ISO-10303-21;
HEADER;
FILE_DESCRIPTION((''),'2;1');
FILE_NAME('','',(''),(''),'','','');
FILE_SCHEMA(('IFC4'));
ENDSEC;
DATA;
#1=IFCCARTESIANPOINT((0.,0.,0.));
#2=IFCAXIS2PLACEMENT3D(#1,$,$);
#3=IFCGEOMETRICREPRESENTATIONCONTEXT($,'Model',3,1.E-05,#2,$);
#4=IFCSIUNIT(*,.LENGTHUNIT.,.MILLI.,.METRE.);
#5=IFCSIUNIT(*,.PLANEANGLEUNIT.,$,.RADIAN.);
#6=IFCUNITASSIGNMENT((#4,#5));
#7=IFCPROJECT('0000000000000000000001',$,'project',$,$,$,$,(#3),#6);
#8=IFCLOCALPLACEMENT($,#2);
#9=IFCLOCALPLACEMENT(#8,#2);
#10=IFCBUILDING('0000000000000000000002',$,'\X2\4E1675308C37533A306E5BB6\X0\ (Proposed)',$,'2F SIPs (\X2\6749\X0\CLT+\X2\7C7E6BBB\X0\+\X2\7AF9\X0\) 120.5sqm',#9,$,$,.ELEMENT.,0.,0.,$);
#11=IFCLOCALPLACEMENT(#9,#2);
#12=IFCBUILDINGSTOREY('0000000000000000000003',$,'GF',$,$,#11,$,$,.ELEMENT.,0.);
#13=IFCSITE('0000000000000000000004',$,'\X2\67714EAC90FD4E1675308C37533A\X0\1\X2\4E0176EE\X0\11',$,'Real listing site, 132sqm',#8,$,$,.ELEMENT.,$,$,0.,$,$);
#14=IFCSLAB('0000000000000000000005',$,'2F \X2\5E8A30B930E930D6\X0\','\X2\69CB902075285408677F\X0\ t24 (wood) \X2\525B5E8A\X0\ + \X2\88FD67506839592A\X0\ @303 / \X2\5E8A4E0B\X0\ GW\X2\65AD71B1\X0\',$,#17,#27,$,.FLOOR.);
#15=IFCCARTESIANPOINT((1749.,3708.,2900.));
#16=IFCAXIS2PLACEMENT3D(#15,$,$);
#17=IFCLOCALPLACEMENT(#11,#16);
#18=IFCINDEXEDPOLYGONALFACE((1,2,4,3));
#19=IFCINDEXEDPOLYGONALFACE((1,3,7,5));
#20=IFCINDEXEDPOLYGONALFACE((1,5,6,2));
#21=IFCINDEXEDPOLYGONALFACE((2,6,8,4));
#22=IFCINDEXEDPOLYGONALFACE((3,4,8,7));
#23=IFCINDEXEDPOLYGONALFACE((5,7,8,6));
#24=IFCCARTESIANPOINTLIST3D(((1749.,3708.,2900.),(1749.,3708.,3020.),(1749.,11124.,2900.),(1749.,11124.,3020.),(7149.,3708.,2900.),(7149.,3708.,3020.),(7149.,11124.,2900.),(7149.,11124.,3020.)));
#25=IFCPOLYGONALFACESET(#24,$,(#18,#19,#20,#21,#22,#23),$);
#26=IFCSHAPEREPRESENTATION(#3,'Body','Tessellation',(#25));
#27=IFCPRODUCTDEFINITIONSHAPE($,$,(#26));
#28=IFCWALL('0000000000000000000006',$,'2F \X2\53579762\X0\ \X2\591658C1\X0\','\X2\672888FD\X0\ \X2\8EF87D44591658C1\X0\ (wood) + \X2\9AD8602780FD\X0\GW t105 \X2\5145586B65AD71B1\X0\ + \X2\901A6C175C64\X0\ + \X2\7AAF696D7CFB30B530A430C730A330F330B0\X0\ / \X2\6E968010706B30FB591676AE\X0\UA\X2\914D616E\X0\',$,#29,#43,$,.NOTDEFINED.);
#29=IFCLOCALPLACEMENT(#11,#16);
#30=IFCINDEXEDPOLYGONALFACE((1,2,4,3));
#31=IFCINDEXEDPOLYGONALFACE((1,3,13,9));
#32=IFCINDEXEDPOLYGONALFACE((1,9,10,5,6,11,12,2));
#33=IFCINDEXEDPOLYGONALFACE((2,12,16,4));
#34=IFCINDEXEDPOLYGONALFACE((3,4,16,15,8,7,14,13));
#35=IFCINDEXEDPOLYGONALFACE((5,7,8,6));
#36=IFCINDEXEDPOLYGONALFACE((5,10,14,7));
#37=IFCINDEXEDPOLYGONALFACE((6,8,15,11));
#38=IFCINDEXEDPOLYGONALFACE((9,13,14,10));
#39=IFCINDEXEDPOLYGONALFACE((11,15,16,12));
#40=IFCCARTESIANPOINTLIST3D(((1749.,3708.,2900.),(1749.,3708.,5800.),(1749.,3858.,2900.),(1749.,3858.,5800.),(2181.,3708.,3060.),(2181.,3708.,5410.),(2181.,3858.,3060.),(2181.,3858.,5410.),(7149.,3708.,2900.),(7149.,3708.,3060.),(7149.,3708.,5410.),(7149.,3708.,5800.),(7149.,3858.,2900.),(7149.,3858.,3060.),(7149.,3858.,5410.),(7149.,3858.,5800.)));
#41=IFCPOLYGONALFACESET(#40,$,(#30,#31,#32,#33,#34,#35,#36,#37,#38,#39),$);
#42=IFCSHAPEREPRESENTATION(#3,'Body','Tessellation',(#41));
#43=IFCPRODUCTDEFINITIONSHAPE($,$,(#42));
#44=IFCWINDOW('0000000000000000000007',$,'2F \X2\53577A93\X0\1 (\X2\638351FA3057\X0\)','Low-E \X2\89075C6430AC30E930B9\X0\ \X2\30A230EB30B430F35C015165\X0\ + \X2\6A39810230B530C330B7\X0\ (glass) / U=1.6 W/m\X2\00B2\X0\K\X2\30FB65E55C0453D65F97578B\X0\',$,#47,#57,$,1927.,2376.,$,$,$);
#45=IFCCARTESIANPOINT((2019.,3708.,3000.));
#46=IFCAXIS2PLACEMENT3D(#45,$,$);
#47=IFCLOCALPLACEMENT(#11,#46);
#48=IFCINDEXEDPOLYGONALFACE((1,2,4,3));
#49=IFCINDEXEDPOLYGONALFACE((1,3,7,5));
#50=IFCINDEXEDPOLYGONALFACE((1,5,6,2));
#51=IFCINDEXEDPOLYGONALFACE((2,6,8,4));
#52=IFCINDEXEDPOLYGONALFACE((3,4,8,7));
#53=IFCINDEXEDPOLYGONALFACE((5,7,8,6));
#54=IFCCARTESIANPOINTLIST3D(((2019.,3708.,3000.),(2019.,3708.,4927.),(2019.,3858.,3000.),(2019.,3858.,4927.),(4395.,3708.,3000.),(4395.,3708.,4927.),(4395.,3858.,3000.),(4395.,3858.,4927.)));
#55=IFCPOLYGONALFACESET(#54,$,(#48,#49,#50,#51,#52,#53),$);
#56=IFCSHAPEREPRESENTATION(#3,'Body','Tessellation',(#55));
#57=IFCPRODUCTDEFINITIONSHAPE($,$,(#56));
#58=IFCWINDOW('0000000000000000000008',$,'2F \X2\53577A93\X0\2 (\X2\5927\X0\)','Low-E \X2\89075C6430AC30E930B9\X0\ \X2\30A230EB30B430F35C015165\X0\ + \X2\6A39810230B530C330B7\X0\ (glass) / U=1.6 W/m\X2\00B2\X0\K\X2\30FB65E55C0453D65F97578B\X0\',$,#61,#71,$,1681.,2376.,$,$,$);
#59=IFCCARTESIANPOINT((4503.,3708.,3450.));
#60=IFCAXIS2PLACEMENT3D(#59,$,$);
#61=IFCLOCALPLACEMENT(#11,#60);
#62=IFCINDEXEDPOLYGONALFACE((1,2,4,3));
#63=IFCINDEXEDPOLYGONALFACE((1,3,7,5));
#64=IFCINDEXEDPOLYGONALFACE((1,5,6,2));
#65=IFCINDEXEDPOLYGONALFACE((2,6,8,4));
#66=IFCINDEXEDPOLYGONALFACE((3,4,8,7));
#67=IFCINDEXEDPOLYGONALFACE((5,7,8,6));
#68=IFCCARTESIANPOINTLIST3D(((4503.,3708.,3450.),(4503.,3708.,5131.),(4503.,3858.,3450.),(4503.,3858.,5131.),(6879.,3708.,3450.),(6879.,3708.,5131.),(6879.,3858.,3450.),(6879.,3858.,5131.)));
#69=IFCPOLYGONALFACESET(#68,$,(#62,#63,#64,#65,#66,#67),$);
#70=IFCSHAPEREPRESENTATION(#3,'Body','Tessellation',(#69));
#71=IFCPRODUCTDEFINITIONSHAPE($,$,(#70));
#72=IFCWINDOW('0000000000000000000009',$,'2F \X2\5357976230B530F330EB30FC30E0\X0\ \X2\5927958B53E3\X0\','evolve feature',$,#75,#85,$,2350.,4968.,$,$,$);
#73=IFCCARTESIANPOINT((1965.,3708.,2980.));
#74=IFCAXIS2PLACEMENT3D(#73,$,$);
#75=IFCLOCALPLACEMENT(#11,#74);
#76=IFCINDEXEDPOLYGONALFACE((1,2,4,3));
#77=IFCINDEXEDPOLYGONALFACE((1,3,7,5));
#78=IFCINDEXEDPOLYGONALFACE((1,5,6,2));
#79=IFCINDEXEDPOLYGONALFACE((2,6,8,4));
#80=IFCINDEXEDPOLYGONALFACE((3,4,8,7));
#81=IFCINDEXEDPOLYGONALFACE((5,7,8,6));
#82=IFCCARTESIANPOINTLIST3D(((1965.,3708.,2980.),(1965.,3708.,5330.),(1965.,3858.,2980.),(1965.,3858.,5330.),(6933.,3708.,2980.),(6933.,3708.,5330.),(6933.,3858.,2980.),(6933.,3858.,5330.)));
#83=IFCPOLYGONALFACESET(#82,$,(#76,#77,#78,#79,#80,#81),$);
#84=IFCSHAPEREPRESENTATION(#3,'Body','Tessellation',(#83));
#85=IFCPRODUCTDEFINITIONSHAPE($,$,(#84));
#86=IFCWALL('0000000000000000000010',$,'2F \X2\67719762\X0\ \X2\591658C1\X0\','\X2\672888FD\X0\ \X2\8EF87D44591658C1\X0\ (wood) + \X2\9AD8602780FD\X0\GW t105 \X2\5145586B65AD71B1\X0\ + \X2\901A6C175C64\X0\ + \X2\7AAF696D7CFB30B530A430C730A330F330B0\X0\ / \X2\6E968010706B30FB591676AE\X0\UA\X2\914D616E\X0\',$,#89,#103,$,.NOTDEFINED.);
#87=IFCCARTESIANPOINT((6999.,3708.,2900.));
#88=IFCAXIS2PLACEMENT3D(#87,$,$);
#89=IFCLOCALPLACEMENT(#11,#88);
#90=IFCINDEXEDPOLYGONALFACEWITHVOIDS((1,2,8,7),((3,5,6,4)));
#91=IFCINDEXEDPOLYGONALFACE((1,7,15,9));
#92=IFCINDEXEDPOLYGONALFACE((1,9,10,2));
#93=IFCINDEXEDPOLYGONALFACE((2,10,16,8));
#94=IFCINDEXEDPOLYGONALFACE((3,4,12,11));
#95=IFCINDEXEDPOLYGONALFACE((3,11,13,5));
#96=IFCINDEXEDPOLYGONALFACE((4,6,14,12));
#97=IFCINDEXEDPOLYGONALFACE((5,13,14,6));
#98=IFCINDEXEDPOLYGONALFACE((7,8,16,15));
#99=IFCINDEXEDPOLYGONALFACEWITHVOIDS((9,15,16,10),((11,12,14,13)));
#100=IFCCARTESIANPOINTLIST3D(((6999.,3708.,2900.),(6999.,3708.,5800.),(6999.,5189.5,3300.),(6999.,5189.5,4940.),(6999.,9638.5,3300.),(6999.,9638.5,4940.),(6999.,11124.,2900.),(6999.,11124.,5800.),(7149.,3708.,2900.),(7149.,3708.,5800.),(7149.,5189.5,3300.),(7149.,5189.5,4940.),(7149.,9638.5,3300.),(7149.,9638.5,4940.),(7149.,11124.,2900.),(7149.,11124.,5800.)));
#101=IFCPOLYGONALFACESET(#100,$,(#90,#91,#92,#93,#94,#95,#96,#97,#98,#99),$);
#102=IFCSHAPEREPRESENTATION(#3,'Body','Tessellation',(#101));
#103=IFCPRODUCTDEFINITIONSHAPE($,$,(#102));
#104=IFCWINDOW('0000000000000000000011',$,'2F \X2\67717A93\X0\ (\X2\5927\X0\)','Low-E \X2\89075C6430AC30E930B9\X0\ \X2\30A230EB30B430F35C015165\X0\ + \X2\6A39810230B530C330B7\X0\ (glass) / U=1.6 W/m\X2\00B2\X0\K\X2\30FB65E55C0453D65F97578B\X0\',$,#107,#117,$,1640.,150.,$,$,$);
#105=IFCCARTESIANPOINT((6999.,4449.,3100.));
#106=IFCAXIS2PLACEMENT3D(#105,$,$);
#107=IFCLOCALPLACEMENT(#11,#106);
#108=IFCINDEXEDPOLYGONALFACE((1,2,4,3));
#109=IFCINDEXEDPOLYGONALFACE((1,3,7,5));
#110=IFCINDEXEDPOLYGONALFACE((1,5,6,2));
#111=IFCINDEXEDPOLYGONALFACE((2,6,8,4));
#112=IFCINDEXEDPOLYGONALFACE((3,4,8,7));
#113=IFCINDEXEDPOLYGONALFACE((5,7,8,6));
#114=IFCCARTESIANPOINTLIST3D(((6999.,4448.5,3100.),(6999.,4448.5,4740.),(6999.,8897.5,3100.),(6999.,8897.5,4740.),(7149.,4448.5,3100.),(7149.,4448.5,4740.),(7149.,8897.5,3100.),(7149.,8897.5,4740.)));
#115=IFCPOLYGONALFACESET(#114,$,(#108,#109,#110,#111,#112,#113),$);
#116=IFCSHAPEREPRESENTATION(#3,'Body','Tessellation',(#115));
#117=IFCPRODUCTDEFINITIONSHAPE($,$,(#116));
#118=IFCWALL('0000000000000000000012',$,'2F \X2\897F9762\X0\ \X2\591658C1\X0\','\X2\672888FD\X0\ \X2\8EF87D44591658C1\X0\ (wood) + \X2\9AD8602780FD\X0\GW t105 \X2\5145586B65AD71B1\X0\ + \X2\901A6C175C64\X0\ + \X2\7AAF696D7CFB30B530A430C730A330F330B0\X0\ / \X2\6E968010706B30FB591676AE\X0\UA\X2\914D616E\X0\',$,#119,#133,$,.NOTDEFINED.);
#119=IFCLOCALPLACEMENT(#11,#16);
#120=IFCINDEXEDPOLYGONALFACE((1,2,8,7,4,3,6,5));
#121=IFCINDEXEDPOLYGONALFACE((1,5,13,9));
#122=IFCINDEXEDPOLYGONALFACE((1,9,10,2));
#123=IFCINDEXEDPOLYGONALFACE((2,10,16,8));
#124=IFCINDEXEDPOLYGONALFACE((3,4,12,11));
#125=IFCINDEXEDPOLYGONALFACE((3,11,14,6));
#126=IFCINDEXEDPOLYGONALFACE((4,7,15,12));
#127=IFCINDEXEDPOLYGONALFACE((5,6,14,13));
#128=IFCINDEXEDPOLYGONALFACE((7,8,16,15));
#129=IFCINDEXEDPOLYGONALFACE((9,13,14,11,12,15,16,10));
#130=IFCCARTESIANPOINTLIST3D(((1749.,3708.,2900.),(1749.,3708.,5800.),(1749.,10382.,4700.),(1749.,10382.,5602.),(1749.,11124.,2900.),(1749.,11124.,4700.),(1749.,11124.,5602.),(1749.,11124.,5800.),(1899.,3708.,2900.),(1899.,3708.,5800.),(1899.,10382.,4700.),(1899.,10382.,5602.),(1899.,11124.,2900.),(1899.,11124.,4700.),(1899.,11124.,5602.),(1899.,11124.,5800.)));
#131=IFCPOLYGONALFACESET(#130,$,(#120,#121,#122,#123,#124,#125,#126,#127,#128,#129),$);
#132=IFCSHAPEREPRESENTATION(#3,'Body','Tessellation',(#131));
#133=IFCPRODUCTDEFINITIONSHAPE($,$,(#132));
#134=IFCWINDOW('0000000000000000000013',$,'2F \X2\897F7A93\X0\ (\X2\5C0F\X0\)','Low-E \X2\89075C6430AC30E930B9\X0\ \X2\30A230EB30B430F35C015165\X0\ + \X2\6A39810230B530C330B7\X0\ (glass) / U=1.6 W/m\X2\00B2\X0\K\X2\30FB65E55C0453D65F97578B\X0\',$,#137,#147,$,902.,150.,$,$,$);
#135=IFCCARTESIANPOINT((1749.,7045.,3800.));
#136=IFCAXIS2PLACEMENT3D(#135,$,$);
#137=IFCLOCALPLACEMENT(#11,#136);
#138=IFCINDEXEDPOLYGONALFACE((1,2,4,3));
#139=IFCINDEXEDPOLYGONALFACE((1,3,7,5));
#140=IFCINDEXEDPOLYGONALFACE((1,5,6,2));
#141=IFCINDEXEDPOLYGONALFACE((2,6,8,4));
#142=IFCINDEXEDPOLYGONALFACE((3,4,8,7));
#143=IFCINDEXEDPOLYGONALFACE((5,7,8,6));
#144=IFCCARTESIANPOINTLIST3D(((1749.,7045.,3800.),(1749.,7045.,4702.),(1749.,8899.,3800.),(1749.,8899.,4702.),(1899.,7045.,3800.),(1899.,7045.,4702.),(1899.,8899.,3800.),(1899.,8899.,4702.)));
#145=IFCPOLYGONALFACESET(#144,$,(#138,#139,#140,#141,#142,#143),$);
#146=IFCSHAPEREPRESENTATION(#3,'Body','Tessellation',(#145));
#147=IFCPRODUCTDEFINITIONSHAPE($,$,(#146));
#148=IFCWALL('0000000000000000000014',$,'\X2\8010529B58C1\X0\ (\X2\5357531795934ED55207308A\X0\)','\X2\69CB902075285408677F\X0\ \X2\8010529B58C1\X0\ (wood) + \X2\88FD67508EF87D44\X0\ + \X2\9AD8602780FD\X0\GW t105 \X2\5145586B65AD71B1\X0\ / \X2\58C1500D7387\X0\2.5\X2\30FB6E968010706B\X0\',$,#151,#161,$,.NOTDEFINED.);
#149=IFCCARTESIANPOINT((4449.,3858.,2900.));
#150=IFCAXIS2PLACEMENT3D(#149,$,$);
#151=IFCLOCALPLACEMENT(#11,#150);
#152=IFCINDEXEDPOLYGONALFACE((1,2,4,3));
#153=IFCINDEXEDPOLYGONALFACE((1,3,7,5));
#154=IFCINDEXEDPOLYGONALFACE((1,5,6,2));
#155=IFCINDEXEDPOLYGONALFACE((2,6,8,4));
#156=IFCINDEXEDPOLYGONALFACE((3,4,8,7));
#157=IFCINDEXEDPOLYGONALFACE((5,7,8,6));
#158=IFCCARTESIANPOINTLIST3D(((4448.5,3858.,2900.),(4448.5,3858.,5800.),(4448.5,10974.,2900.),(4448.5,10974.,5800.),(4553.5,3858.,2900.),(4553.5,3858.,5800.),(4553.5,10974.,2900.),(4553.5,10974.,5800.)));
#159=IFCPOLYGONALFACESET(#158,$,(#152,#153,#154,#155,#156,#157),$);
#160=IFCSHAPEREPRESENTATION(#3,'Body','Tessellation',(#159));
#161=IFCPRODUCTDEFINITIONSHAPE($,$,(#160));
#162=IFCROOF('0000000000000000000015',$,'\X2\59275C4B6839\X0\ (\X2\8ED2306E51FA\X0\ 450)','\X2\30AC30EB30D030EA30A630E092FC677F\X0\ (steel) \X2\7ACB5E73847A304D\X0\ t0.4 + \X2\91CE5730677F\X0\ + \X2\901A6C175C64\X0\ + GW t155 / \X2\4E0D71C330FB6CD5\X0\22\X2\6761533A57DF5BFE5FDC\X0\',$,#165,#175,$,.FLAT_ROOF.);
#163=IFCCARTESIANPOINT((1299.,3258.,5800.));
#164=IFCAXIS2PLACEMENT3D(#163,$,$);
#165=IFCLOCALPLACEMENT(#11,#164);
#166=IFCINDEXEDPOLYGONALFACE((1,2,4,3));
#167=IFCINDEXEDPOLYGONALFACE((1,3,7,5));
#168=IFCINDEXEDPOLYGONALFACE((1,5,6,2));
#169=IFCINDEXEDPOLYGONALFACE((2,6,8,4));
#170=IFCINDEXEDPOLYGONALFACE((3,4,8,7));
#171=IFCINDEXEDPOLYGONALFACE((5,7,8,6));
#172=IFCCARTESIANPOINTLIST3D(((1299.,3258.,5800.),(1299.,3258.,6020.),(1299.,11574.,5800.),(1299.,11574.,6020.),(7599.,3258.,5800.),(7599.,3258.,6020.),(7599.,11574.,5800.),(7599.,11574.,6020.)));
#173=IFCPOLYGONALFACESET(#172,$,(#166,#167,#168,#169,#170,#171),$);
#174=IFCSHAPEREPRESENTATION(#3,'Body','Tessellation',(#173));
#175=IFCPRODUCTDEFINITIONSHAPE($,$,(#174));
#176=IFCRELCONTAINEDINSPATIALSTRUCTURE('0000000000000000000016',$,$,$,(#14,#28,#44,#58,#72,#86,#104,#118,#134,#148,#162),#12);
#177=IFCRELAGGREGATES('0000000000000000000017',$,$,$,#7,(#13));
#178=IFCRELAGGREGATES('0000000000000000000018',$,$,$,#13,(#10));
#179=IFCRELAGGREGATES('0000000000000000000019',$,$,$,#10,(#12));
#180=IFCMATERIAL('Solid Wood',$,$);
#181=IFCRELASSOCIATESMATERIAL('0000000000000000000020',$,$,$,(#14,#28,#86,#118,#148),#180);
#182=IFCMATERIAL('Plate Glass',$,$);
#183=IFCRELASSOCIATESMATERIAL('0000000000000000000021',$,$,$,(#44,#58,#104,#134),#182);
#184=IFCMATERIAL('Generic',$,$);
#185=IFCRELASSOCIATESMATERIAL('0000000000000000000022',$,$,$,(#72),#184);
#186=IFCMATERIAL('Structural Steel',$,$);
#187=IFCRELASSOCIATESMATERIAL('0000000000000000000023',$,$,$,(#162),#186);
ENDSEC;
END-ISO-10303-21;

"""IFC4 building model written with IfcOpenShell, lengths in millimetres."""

from ifc_helpers import new_model, si_unit, frame, frame_2d, origin, place, context, project, spatial, rectangle, extrude, material, element, fill, save


model = new_model("IFC4")

# Units and contexts
model_context = context("Model", 3, precision=1e-05, world=origin())
ifc_project = project(units=[si_unit("LENGTHUNIT", "METRE", prefix="MILLI"), si_unit("PLANEANGLEUNIT", "RADIAN")], contexts=[model_context])

# Site, building, storey
site_placement = place(None, origin())
site = spatial("IfcSite", under=ifc_project, at=site_placement, Name="東京都世田谷区1丁目11", ObjectType="Real listing site, 132sqm", CompositionType="ELEMENT", RefElevation=0.0)
building_placement = place(site_placement, origin())
building = spatial("IfcBuilding", under=site, at=building_placement, Name="世田谷区の家 (Proposed)", ObjectType="2F SIPs (杉CLT+籾殻+竹) 120.5sqm", CompositionType="ELEMENT", ElevationOfRefHeight=0.0, ElevationOfTerrain=0.0)
storey_placement = place(building_placement, origin())
storey = spatial("IfcBuildingStorey", under=building, at=storey_placement, Name="GF", CompositionType="ELEMENT", Elevation=0.0)

# Slab
ifc_material_1 = material(Name="Solid Wood")
slab_placement = place(storey_placement, frame((1749.0, 3708.0, 2900.0)))
element("IfcSlab", 1, at=slab_placement, inside=storey, material=ifc_material_1, Name="2F 床スラブ", Description="構造用合板 t24 (wood) 剛床 + 製材根太 @303 / 床下 GW断熱", PredefinedType="FLOOR", context=model_context, shape_type="SweptSolid", body=[
    extrude(rectangle(XDim=5400.0, YDim=7416.0, at=frame_2d((2700.0, 3708.0))), frame((1749.0, 3708.0, 2900.0)), (0.0, 0.0, 1.0), 120.0),
])

# Wall, openings, windows
wall_1_placement = place(storey_placement, frame((1749.0, 3708.0, 2900.0)))
wall_1 = element("IfcWall", 2, at=wall_1_placement, inside=storey, material=ifc_material_1, Name="2F 南面 外壁", Description="木製 軸組外壁 (wood) + 高性能GW t105 充填断熱 + 通気層 + 窯業系サイディング / 準耐火・外皮UA配慮", PredefinedType="NOTDEFINED", context=model_context, shape_type="SweptSolid", body=[
    extrude(rectangle(XDim=5400.0, YDim=150.0, at=frame_2d((2700.0, 75.0))), frame((1749.0, 3708.0, 2900.0)), (0.0, 0.0, 1.0), 2900.0),
])
opening_1_placement = place(storey_placement, frame((2019.0, 3708.0, 3000.0)))
opening_1 = element("IfcOpeningElement", 3, at=opening_1_placement, cuts=wall_1, PredefinedType="NOTDEFINED", context=model_context, shape_type="SweptSolid", body=[
    extrude(rectangle(XDim=2376.0, YDim=150.0, at=frame_2d((1188.0, 75.0))), frame((2019.0, 3708.0, 3000.0)), (0.0, 0.0, 1.0), 1927.0),
])
opening_2_placement = place(storey_placement, frame((4503.0, 3708.0, 3450.0)))
opening_2 = element("IfcOpeningElement", 4, at=opening_2_placement, cuts=wall_1, PredefinedType="NOTDEFINED", context=model_context, shape_type="SweptSolid", body=[
    extrude(rectangle(XDim=2376.0, YDim=150.0, at=frame_2d((1188.0, 75.0))), frame((4503.0, 3708.0, 3450.0)), (0.0, 0.0, 1.0), 1681.0),
])
opening_3_placement = place(storey_placement, frame((1965.0, 3708.0, 2980.0)))
opening_3 = element("IfcOpeningElement", 5, at=opening_3_placement, cuts=wall_1, PredefinedType="NOTDEFINED", context=model_context, shape_type="SweptSolid", body=[
    extrude(rectangle(XDim=4968.0, YDim=150.0, at=frame_2d((2484.0, 75.0))), frame((1965.0, 3708.0, 2980.0)), (0.0, 0.0, 1.0), 2350.0),
])
ifc_material_2 = material(Name="Plate Glass")
window_1_placement = place(storey_placement, frame((2019.0, 3708.0, 3000.0)))
window_1 = element("IfcWindow", 6, at=window_1_placement, inside=storey, material=ifc_material_2, Name="2F 南窓1 (掃出し)", Description="Low-E 複層ガラス アルゴン封入 + 樹脂サッシ (glass) / U=1.6 W/m²K・日射取得型", OverallHeight=1927.0, OverallWidth=2376.0, context=model_context, shape_type="SweptSolid", body=[
    extrude(rectangle(XDim=2376.0, YDim=150.0, at=frame_2d((1188.0, 75.0))), frame((2019.0, 3708.0, 3000.0)), (0.0, 0.0, 1.0), 1927.0),
])
fill(opening_1, window_1)
window_2_placement = place(storey_placement, frame((4503.0, 3708.0, 3450.0)))
window_2 = element("IfcWindow", 7, at=window_2_placement, inside=storey, material=ifc_material_2, Name="2F 南窓2 (大)", Description="Low-E 複層ガラス アルゴン封入 + 樹脂サッシ (glass) / U=1.6 W/m²K・日射取得型", OverallHeight=1681.0, OverallWidth=2376.0, context=model_context, shape_type="SweptSolid", body=[
    extrude(rectangle(XDim=2376.0, YDim=150.0, at=frame_2d((1188.0, 75.0))), frame((4503.0, 3708.0, 3450.0)), (0.0, 0.0, 1.0), 1681.0),
])
fill(opening_2, window_2)
ifc_material_3 = material(Name="Generic")
window_3_placement = place(storey_placement, frame((1965.0, 3708.0, 2980.0)))
window_3 = element("IfcWindow", 8, at=window_3_placement, inside=storey, material=ifc_material_3, Name="2F 南面サンルーム 大開口", Description="evolve feature", OverallHeight=2350.0, OverallWidth=4968.0, context=model_context, shape_type="SweptSolid", body=[
    extrude(rectangle(XDim=4968.0, YDim=150.0, at=frame_2d((2484.0, 75.0))), frame((1965.0, 3708.0, 2980.0)), (0.0, 0.0, 1.0), 2350.0),
])
fill(opening_3, window_3)

# Walls, openings, windows
wall_2_placement = place(storey_placement, frame((6999.0, 3708.0, 2900.0)))
wall_2 = element("IfcWall", 9, at=wall_2_placement, inside=storey, material=ifc_material_1, Name="2F 東面 外壁", Description="木製 軸組外壁 (wood) + 高性能GW t105 充填断熱 + 通気層 + 窯業系サイディング / 準耐火・外皮UA配慮", PredefinedType="NOTDEFINED", context=model_context, shape_type="SweptSolid", body=[
    extrude(rectangle(XDim=150.0, YDim=7416.0, at=frame_2d((75.0, 3708.0))), frame((6999.0, 3708.0, 2900.0)), (0.0, 0.0, 1.0), 2900.0),
])
opening_4_placement = place(storey_placement, frame((6999.0, 4449.0, 3100.0)))
opening_4 = element("IfcOpeningElement", 10, at=opening_4_placement, cuts=wall_2, PredefinedType="NOTDEFINED", context=model_context, shape_type="SweptSolid", body=[
    extrude(rectangle(XDim=150.0, YDim=4449.0, at=frame_2d((75.0, 2224.0))), frame((6999.0, 4449.0, 3100.0)), (0.0, 0.0, 1.0), 1640.0),
])
window_4_placement = place(storey_placement, frame((6999.0, 4449.0, 3100.0)))
window_4 = element("IfcWindow", 11, at=window_4_placement, inside=storey, material=ifc_material_2, Name="2F 東窓 (大)", Description="Low-E 複層ガラス アルゴン封入 + 樹脂サッシ (glass) / U=1.6 W/m²K・日射取得型", OverallHeight=1640.0, OverallWidth=150.0, context=model_context, shape_type="SweptSolid", body=[
    extrude(rectangle(XDim=150.0, YDim=4449.0, at=frame_2d((75.0, 2224.0))), frame((6999.0, 4449.0, 3100.0)), (0.0, 0.0, 1.0), 1640.0),
])
fill(opening_4, window_4)
wall_3_placement = place(storey_placement, frame((1749.0, 3708.0, 2900.0)))
wall_3 = element("IfcWall", 12, at=wall_3_placement, inside=storey, material=ifc_material_1, Name="2F 西面 外壁", Description="木製 軸組外壁 (wood) + 高性能GW t105 充填断熱 + 通気層 + 窯業系サイディング / 準耐火・外皮UA配慮", PredefinedType="NOTDEFINED", context=model_context, shape_type="SweptSolid", body=[
    extrude(rectangle(XDim=150.0, YDim=7416.0, at=frame_2d((75.0, 3708.0))), frame((1749.0, 3708.0, 2900.0)), (0.0, 0.0, 1.0), 2900.0),
])
opening_5_placement = place(storey_placement, frame((1749.0, 7045.0, 3800.0)))
opening_5 = element("IfcOpeningElement", 13, at=opening_5_placement, cuts=wall_3, PredefinedType="NOTDEFINED", context=model_context, shape_type="SweptSolid", body=[
    extrude(rectangle(XDim=150.0, YDim=1854.0, at=frame_2d((75.0, 927.0))), frame((1749.0, 7045.0, 3800.0)), (0.0, 0.0, 1.0), 902.0),
])
window_5_placement = place(storey_placement, frame((1749.0, 7045.0, 3800.0)))
window_5 = element("IfcWindow", 14, at=window_5_placement, inside=storey, material=ifc_material_2, Name="2F 西窓 (小)", Description="Low-E 複層ガラス アルゴン封入 + 樹脂サッシ (glass) / U=1.6 W/m²K・日射取得型", OverallHeight=902.0, OverallWidth=150.0, context=model_context, shape_type="SweptSolid", body=[
    extrude(rectangle(XDim=150.0, YDim=1854.0, at=frame_2d((75.0, 927.0))), frame((1749.0, 7045.0, 3800.0)), (0.0, 0.0, 1.0), 902.0),
])
fill(opening_5, window_5)

# Wall
wall_4_placement = place(storey_placement, frame((4449.0, 3858.0, 2900.0)))
element("IfcWall", 15, at=wall_4_placement, inside=storey, material=ifc_material_1, Name="耐力壁 (南北間仕切り)", Description="構造用合板 耐力壁 (wood) + 製材軸組 + 高性能GW t105 充填断熱 / 壁倍率2.5・準耐火", PredefinedType="NOTDEFINED", context=model_context, shape_type="SweptSolid", body=[
    extrude(rectangle(XDim=105.0, YDim=7116.0, at=frame_2d((52.0, 3558.0))), frame((4449.0, 3858.0, 2900.0)), (0.0, 0.0, 1.0), 2900.0),
])

# Roof
ifc_material_4 = material(Name="Structural Steel")
roof_1_placement = place(storey_placement, frame((1299.0, 3258.0, 5800.0)))
element("IfcRoof", 16, at=roof_1_placement, inside=storey, material=ifc_material_4, Name="大屋根 (軒の出 450)", Description="ガルバリウム鋼板 (steel) 立平葺き t0.4 + 野地板 + 通気層 + GW t155 / 不燃・法22条区域対応", PredefinedType="FLAT_ROOF", context=model_context, shape_type="SweptSolid", body=[
    extrude(rectangle(XDim=6300.0, YDim=8316.0, at=frame_2d((3150.0, 4158.0))), frame((1299.0, 3258.0, 5800.0)), (0.0, 0.0, 1.0), 220.0),
])

save(model, "model.ifc")
